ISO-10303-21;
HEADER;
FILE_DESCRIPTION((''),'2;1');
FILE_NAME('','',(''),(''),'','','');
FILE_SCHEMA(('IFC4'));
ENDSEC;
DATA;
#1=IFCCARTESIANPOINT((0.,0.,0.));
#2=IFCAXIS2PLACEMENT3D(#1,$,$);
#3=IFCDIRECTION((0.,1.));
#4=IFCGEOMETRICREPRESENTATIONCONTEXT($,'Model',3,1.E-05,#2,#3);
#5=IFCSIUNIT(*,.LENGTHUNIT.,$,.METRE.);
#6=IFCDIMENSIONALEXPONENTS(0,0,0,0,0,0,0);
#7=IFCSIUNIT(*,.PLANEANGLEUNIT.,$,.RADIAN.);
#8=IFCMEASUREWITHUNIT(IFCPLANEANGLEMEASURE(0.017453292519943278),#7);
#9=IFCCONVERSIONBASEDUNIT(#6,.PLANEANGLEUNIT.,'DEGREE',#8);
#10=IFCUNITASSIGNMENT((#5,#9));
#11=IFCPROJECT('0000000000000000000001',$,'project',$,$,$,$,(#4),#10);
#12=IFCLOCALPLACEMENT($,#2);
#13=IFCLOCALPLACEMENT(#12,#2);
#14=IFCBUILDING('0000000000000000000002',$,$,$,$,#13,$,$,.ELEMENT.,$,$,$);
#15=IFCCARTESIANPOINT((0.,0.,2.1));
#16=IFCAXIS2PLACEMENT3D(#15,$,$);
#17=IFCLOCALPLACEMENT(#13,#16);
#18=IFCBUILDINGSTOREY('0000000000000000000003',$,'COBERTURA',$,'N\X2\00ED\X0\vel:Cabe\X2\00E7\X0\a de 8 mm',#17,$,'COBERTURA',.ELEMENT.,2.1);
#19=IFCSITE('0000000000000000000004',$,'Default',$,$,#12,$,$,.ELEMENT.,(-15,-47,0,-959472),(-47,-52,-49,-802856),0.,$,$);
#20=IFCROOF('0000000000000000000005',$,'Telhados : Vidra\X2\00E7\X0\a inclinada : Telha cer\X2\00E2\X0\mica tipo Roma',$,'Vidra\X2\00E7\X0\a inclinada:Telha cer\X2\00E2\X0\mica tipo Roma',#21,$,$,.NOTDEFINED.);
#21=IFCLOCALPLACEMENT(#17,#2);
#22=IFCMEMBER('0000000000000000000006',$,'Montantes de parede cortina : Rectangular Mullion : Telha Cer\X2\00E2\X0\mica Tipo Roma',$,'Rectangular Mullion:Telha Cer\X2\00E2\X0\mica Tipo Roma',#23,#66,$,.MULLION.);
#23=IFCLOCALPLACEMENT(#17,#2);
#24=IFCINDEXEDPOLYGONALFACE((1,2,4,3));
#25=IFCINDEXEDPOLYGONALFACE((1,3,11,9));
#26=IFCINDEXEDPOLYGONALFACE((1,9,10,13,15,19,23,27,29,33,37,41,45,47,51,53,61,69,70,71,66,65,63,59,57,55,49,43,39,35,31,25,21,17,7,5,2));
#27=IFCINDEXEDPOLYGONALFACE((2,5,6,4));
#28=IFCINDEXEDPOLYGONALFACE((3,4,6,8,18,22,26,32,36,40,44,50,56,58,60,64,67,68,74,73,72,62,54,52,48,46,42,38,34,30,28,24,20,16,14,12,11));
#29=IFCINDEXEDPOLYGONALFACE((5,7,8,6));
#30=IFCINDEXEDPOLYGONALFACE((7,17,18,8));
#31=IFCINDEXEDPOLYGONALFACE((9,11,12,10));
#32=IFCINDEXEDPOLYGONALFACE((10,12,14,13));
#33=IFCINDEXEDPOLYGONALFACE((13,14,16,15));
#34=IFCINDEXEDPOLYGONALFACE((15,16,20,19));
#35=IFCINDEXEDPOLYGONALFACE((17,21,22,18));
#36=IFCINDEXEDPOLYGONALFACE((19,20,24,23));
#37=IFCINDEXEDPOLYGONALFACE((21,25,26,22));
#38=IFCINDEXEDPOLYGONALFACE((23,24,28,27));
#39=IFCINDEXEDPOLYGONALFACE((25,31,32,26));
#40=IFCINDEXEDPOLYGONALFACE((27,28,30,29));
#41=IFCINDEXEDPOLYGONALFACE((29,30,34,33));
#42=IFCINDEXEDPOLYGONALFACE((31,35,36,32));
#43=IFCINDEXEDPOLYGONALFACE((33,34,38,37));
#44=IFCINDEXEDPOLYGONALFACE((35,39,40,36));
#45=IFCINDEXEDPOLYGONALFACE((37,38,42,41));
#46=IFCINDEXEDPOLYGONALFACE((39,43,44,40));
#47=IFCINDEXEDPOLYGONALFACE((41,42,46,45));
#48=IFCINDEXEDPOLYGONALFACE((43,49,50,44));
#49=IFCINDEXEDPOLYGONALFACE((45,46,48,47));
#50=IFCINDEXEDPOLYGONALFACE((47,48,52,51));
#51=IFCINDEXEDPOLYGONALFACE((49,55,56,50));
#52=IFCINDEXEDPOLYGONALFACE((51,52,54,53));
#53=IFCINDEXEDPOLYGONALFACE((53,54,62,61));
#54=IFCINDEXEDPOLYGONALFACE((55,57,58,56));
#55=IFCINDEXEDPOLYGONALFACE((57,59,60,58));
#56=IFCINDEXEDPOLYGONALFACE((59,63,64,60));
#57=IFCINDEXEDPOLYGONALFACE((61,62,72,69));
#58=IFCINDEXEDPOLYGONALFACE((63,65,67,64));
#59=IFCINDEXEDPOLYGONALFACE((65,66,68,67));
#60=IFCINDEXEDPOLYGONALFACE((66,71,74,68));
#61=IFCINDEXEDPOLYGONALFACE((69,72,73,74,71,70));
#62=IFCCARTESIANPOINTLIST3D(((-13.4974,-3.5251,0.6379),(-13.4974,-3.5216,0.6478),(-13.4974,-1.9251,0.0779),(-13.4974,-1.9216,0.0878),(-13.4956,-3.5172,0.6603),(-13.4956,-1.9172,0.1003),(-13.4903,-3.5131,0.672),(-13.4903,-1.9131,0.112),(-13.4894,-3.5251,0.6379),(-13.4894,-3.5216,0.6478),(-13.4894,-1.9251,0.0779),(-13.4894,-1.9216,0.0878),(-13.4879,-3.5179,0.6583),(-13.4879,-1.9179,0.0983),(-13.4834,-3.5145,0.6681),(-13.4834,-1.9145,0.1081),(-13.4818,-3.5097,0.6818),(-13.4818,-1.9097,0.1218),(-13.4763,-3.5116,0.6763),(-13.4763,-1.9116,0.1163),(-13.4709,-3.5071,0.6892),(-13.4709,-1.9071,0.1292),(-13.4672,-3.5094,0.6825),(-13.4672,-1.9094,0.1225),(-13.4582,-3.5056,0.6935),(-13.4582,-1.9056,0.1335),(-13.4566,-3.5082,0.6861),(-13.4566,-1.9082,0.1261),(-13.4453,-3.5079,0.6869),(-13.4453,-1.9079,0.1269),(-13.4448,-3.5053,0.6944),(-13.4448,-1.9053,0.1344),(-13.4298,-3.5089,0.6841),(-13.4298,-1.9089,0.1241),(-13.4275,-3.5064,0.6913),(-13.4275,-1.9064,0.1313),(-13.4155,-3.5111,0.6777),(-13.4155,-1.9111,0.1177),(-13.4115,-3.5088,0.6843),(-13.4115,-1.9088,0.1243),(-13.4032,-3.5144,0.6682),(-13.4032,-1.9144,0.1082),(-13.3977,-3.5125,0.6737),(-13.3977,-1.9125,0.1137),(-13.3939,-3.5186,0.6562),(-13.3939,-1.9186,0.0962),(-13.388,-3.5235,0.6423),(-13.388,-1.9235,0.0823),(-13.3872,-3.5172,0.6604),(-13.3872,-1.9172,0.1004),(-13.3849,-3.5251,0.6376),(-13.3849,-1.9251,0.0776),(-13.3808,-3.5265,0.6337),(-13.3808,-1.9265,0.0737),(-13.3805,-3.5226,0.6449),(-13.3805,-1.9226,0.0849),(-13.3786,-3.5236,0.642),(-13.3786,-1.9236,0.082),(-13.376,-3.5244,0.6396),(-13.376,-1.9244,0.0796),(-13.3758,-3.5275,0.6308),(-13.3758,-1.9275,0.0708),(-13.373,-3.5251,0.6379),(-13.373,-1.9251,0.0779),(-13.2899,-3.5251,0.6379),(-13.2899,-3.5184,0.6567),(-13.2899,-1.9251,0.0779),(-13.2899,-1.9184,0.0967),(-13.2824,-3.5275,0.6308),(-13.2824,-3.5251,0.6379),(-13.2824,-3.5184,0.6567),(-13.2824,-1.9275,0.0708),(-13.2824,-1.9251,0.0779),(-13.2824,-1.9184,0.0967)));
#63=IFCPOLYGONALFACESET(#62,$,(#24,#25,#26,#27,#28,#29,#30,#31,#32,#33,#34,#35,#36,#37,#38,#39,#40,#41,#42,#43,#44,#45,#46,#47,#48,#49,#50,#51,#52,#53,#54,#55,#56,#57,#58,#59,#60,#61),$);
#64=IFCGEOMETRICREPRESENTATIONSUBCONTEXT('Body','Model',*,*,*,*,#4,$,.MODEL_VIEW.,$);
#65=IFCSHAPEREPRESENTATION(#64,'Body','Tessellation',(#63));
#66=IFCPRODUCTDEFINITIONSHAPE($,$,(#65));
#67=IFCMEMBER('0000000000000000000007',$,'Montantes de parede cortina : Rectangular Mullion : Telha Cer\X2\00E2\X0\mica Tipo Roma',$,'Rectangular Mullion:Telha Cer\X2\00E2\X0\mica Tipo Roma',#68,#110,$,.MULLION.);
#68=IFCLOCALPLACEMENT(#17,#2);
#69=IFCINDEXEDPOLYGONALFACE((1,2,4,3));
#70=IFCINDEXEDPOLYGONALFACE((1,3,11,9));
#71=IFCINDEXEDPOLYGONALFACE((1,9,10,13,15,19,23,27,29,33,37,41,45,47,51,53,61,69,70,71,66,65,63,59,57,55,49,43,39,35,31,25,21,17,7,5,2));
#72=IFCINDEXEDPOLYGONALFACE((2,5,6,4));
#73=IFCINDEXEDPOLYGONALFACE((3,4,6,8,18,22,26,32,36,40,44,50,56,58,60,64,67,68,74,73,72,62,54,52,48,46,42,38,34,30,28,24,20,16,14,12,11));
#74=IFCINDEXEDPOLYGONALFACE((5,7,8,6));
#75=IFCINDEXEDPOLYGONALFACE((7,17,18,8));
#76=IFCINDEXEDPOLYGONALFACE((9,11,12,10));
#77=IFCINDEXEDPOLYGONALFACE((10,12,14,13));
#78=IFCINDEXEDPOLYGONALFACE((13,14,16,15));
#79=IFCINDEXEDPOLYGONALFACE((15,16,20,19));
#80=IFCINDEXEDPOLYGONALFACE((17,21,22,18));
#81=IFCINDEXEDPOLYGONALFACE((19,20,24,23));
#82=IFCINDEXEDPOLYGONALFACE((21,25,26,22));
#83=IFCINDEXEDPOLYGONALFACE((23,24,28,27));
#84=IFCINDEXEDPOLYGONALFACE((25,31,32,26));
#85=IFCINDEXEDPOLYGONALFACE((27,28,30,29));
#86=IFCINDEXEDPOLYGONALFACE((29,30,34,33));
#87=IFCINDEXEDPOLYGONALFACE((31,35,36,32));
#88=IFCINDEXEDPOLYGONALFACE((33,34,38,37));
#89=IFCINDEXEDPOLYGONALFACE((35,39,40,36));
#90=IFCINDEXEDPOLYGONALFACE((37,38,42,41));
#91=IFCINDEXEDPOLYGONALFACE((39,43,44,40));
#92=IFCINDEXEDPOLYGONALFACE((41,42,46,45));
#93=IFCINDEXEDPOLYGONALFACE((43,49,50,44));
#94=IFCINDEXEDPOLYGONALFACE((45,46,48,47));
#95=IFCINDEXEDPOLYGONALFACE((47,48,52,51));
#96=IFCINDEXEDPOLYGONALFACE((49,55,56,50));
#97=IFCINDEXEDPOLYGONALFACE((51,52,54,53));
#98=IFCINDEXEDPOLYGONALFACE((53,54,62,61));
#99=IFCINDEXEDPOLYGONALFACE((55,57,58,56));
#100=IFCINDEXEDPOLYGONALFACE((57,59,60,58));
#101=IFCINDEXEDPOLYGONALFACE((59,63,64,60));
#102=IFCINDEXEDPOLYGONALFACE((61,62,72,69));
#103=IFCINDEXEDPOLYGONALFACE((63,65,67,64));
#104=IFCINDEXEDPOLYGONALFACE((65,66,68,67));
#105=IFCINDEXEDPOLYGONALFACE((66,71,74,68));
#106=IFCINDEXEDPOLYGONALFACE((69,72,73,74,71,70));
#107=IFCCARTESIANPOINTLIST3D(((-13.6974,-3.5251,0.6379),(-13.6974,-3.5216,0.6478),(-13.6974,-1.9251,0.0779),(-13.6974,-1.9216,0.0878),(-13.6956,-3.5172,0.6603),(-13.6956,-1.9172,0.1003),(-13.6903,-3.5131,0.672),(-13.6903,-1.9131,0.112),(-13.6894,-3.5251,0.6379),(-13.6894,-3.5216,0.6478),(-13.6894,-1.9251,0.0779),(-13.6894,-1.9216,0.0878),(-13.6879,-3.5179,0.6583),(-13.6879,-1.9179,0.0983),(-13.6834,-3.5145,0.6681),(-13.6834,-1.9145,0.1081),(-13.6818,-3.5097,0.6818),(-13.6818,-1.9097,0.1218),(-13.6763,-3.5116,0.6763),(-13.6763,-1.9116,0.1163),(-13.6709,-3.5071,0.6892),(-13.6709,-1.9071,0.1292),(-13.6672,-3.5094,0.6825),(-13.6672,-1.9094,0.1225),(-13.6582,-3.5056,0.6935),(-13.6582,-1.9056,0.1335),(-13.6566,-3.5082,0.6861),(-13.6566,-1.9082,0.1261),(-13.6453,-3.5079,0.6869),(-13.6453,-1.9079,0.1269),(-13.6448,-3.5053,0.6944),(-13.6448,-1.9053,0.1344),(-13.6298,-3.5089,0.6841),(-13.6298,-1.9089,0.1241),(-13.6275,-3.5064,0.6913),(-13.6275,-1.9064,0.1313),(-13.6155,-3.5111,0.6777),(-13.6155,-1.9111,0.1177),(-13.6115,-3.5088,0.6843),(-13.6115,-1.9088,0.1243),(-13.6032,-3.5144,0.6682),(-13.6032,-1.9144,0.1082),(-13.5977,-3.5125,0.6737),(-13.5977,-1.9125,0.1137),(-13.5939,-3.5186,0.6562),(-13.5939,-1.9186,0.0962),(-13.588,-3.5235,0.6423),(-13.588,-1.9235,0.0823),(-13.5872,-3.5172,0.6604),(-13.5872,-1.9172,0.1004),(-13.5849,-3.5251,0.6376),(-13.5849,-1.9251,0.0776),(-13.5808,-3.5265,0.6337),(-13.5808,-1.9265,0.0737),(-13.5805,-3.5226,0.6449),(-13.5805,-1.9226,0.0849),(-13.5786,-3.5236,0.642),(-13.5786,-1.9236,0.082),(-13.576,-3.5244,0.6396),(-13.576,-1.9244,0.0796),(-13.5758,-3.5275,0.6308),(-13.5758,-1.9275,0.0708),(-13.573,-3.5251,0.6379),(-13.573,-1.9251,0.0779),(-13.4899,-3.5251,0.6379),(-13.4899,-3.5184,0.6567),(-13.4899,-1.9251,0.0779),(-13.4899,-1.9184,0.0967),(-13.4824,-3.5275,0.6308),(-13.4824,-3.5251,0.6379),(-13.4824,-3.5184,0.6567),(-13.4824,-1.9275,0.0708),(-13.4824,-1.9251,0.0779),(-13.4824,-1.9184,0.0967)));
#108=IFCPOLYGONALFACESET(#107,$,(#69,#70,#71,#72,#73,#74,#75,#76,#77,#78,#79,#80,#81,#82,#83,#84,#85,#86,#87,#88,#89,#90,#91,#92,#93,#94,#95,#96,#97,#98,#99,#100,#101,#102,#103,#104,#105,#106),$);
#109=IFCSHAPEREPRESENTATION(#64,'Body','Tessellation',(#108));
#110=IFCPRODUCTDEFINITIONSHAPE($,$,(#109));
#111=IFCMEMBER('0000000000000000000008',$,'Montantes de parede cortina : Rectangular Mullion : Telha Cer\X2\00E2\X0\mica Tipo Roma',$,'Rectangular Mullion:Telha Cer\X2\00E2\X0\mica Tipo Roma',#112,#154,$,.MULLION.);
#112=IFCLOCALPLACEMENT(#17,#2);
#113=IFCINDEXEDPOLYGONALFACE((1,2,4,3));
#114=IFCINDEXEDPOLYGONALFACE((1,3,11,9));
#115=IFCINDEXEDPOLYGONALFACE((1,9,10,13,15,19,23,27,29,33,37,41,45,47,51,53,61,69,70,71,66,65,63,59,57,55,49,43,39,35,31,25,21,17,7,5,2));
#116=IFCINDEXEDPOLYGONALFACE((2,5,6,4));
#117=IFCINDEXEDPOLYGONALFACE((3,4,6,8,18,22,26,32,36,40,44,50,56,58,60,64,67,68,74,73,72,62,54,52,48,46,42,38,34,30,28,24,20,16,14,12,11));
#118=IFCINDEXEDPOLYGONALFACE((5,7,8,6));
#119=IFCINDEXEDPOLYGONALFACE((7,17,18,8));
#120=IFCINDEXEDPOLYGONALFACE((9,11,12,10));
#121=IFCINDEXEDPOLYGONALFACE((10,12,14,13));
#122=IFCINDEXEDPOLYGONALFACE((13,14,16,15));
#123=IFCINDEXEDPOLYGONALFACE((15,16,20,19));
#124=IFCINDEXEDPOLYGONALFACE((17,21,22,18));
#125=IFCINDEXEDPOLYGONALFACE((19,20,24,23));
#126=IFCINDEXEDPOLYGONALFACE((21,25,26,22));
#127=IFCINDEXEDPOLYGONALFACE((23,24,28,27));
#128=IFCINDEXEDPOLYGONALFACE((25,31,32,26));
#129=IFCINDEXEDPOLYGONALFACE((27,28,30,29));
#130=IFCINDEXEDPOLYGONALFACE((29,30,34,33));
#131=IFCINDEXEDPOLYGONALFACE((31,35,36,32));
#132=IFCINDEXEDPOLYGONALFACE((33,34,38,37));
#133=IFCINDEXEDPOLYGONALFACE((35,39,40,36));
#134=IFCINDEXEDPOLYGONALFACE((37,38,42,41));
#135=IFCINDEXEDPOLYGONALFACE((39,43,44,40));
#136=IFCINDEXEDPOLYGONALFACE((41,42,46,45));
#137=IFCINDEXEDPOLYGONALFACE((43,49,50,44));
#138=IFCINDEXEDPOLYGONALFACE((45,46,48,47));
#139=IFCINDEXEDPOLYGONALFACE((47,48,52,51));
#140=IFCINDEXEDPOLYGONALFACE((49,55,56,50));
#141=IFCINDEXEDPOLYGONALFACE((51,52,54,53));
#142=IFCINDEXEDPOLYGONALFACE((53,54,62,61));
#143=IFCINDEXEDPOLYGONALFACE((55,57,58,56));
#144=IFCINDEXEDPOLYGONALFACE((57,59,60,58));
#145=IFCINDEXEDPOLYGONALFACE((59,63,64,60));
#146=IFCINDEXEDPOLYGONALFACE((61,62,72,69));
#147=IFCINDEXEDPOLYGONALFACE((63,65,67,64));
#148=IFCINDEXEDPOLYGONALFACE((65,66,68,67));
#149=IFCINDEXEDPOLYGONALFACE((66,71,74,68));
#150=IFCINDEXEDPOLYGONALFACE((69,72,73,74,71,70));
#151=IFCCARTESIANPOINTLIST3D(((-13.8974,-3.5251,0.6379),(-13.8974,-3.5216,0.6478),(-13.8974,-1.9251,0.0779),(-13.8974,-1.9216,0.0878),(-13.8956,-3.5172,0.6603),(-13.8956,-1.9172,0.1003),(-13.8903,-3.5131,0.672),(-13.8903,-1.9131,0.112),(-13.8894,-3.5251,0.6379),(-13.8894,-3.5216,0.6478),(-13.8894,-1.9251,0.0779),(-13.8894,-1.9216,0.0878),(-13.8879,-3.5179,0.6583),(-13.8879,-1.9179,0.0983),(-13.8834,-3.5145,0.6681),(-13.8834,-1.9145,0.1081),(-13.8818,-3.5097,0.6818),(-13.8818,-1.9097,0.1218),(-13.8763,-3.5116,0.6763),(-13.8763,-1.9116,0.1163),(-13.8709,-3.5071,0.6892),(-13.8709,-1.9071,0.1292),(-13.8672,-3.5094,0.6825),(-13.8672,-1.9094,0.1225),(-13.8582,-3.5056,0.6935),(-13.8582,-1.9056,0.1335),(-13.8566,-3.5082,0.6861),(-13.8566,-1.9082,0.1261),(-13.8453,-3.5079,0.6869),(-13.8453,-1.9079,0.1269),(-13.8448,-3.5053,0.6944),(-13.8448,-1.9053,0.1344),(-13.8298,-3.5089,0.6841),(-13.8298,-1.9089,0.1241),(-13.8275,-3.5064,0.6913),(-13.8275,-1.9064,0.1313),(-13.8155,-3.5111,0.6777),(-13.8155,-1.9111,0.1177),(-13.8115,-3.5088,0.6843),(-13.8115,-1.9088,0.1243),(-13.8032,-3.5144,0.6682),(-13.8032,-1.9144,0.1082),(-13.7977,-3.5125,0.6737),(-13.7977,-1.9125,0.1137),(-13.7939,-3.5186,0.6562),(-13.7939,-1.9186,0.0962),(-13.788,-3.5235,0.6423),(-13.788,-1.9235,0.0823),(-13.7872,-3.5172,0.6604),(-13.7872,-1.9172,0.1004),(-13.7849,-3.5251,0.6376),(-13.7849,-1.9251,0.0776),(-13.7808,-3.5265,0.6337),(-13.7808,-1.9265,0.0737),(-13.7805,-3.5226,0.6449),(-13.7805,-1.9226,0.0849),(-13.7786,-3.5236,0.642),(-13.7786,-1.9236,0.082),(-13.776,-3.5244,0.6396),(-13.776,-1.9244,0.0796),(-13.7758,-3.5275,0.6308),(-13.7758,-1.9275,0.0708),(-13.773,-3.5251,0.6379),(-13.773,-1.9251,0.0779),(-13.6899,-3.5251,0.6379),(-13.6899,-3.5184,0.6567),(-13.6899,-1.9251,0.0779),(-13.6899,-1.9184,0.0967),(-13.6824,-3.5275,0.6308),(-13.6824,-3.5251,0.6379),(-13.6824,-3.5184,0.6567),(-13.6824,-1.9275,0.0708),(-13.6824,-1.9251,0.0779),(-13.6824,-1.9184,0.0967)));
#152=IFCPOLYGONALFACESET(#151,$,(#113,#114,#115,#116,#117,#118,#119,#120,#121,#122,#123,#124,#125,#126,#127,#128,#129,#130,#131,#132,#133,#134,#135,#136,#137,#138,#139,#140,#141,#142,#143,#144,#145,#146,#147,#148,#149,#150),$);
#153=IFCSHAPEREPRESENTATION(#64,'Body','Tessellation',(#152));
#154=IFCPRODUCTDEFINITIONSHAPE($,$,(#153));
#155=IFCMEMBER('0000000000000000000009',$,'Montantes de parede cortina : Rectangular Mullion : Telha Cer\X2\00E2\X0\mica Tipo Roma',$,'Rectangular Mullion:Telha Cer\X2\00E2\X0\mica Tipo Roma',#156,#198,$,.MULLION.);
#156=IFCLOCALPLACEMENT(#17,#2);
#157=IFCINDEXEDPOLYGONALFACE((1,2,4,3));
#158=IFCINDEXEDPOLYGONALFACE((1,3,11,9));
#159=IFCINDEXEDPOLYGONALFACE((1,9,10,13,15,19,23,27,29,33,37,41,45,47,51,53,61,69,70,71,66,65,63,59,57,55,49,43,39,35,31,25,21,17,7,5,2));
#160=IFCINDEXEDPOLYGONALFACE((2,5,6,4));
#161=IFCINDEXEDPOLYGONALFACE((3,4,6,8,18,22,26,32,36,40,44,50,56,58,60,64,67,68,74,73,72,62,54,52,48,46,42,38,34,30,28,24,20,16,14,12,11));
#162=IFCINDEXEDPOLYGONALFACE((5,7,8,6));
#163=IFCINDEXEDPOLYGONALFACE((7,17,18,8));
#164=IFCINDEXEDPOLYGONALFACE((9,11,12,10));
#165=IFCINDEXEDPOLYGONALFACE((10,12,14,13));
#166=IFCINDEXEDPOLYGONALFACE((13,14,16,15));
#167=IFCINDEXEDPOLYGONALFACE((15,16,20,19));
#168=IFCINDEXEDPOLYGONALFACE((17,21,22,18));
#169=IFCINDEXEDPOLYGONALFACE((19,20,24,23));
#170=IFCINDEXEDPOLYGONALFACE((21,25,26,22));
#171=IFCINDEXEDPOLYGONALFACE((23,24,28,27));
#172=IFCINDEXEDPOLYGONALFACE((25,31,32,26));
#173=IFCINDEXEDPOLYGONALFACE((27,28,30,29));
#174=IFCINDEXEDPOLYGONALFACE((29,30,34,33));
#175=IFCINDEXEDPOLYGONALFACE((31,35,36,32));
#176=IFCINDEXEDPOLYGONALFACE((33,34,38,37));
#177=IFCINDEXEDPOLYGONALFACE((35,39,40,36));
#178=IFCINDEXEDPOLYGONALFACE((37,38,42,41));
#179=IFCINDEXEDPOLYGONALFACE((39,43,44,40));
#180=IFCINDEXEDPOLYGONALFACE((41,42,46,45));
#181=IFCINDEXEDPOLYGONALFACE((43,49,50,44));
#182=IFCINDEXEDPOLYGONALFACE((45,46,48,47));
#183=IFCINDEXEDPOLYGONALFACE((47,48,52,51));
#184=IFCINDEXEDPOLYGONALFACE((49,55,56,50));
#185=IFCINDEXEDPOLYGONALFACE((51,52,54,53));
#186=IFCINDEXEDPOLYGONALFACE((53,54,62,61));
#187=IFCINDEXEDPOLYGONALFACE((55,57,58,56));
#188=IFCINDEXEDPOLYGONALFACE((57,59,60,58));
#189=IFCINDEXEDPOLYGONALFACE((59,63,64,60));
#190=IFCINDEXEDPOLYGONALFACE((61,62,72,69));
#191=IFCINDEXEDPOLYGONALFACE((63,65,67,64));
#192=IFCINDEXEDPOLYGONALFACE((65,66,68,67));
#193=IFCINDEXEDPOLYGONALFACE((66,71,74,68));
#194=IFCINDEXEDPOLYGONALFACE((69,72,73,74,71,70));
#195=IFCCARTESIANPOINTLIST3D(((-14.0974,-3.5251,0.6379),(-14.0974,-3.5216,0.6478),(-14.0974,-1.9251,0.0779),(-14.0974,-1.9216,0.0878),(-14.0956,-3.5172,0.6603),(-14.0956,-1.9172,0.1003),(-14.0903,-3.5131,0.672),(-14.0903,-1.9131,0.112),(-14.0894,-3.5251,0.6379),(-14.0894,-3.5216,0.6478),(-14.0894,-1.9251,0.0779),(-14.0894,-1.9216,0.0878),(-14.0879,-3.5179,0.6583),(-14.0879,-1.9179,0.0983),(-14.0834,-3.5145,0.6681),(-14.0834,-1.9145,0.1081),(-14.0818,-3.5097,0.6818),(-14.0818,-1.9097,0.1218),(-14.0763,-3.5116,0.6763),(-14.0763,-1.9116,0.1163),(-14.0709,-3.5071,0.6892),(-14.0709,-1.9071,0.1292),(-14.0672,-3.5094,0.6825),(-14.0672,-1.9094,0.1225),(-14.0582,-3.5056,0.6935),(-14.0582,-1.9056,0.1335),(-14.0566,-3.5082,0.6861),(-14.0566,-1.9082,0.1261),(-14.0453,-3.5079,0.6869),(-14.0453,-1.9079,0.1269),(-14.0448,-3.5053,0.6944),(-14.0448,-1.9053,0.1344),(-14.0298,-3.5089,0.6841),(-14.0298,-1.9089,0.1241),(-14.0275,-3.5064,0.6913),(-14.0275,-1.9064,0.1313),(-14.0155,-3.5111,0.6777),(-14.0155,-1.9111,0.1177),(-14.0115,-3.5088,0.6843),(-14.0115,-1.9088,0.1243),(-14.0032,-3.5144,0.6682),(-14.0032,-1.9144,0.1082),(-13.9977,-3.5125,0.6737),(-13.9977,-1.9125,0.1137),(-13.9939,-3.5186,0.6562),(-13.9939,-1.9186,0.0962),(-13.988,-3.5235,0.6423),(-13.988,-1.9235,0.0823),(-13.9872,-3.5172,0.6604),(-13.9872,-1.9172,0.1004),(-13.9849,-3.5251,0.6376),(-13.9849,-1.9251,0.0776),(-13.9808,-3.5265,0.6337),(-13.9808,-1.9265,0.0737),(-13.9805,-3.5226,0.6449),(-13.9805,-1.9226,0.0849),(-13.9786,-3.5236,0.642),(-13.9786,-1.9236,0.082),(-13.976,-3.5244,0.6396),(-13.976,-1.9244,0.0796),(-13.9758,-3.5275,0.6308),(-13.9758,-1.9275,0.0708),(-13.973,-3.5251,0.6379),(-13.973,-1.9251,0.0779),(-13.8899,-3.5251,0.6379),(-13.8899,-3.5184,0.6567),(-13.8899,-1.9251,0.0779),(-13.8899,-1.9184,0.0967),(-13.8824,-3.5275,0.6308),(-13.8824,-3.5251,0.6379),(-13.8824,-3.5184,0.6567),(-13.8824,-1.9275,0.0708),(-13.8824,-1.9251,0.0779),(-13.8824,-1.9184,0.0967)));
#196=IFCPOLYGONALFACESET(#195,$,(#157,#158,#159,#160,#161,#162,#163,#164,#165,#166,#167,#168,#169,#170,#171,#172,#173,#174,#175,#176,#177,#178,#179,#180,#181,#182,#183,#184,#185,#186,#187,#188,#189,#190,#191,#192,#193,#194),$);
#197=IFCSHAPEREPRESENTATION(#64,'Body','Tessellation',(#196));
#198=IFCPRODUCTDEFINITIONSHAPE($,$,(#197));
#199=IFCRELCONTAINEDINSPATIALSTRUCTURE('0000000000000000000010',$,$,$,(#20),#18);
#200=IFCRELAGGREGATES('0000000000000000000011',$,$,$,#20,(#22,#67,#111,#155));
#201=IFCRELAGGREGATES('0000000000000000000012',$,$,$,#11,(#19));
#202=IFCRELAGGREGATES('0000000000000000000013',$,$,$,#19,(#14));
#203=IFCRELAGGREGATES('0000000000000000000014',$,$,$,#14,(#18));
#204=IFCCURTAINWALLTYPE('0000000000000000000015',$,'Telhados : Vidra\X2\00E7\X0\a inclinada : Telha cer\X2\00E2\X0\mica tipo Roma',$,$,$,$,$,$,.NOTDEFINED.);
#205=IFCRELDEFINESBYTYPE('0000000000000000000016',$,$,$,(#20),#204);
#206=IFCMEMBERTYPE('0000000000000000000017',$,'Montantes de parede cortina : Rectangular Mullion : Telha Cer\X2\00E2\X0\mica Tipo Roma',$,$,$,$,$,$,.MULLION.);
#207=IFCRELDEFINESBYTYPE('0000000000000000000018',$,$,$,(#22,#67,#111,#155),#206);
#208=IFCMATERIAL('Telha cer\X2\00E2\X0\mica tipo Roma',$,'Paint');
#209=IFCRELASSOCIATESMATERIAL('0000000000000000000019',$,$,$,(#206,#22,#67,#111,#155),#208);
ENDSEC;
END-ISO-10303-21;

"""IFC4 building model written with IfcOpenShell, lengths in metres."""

from ifc_helpers import new_model, entity, si_unit, converted_unit, direction, frame, origin, place, context, subcontext, project, spatial, line, arc, indexed_curve, outline, extrude, source, transform, mapped, material, type_object, type_shapes, element, aggregate, save


model = new_model("IFC4")

# Units and contexts
model_context = context("Model", 3, precision=1e-05, world=origin(), true_north=direction((0.0, 1.0)))
body_context = subcontext(model_context, "Body", "Model", "MODEL_VIEW")
ifc_project = project(units=[si_unit("LENGTHUNIT", "METRE"), converted_unit("PLANEANGLEUNIT", "DEGREE", entity("IfcPlaneAngleMeasure", 0.017453292519943278), si_unit("PLANEANGLEUNIT", "RADIAN"), dimensions=[0, 0, 0, 0, 0, 0, 0])], contexts=[model_context])

# Site, building, storey
site_placement = place(None, origin())
site = spatial("IfcSite", under=ifc_project, at=site_placement, Name="Default", CompositionType="ELEMENT", RefLatitude=(-15, -47, 0, -959472), RefLongitude=(-47, -52, -49, -802856), RefElevation=0.0)
building_placement = place(site_placement, origin())
building = spatial("IfcBuilding", under=site, at=building_placement, CompositionType="ELEMENT")
storey_placement = place(building_placement, frame((0.0, 0.0, 2.1)))
storey = spatial("IfcBuildingStorey", under=building, at=storey_placement, Name="COBERTURA", ObjectType="Nível:Cabeça de 8 mm", LongName="COBERTURA", CompositionType="ELEMENT", Elevation=2.1)

# Roof, members
curtain_wall_type_1 = type_object("IfcCurtainWallType", Name="Telhados : Vidraça inclinada : Telha cerâmica tipo Roma", PredefinedType="NOTDEFINED")
roof_1_placement = place(storey_placement, frame((0.0, 0.0, -2.1)))
roof_1 = element("IfcRoof", 1, at=roof_1_placement, inside=storey, type_object=curtain_wall_type_1, Name="Telhados : Vidraça inclinada : Telha cerâmica tipo Roma", ObjectType="Vidraça inclinada:Telha cerâmica tipo Roma", PredefinedType="NOTDEFINED")
ifc_material_1 = material(Name="Telha cerâmica tipo Roma", Category="Paint")
member_type_1 = type_object("IfcMemberType", Name="Montantes de parede cortina : Rectangular Mullion : Telha Cerâmica Tipo Roma", PredefinedType="MULLION", material=ifc_material_1)
shared_shape_1 = source(origin(), body_context, "Body", "SweptSolid", [
    extrude(outline(indexed_curve([(0.0114, -0.0188), (0.1048, -0.0188), (0.1048, -0.0113), (0.1048, 0.0087), (0.0973, 0.0087), (0.0973, -0.0113), (0.0142, -0.0113), (0.0098, -0.0083), (0.0067, -0.0038), (-0.017, 0.0327), (-0.0576, 0.0486), (-0.0946, 0.0352), (-0.1102, -0.0008), (-0.1102, -0.0113), (-0.1022, -0.0113), (-0.1022, -0.0008), (-0.0891, 0.0294), (-0.0581, 0.0406), (-0.0218, 0.0263), (-0.0008, -0.0066), (0.0042, -0.0138)], segments=[line(1, 2, 3, 4, 5, 6, 7), arc(7, 8, 9), arc(9, 10, 11), arc(11, 12, 13), line(13, 14, 15, 16), arc(16, 17, 18), arc(18, 19, 20), arc(20, 21, 1)], self_intersect=False)), frame((-0.0027, -0.0938, -4.3552), z_axis=(0.0, 0.0, 1.0), x_axis=(-1.0, 0.0, 0.0)), (0.0, 0.0, 1.0), 1.6952),
])
type_shapes(member_type_1, [shared_shape_1])
member_1_placement = place(roof_1_placement, frame((-13.3899, -6.063, 3.5387), z_axis=(0.0, -0.943858, 0.33035), x_axis=(-1.0, 0.0, 0.0)))
member_1 = element("IfcMember", 2, at=member_1_placement, type_object=member_type_1, material=ifc_material_1, Name="Montantes de parede cortina : Rectangular Mullion : Telha Cerâmica Tipo Roma", ObjectType="Rectangular Mullion:Telha Cerâmica Tipo Roma", PredefinedType="MULLION", context=body_context, shape_type="MappedRepresentation", body=[
    mapped(shared_shape_1, transform((0.0, 0.0, 0.0), scale=1.0)),
])
member_2_placement = place(roof_1_placement, frame((-13.5899, -6.063, 3.5387), z_axis=(0.0, -0.943858, 0.33035), x_axis=(-1.0, 0.0, 0.0)))
member_2 = element("IfcMember", 3, at=member_2_placement, type_object=member_type_1, material=ifc_material_1, Name="Montantes de parede cortina : Rectangular Mullion : Telha Cerâmica Tipo Roma", ObjectType="Rectangular Mullion:Telha Cerâmica Tipo Roma", PredefinedType="MULLION", context=body_context, shape_type="MappedRepresentation", body=[
    mapped(shared_shape_1, transform((0.0, 0.0, 0.0), scale=1.0)),
])
member_3_placement = place(roof_1_placement, frame((-13.7899, -6.063, 3.5387), z_axis=(0.0, -0.943858, 0.33035), x_axis=(-1.0, 0.0, 0.0)))
member_3 = element("IfcMember", 4, at=member_3_placement, type_object=member_type_1, material=ifc_material_1, Name="Montantes de parede cortina : Rectangular Mullion : Telha Cerâmica Tipo Roma", ObjectType="Rectangular Mullion:Telha Cerâmica Tipo Roma", PredefinedType="MULLION", context=body_context, shape_type="MappedRepresentation", body=[
    mapped(shared_shape_1, transform((0.0, 0.0, 0.0), scale=1.0)),
])
member_4_placement = place(roof_1_placement, frame((-13.9899, -6.063, 3.5387), z_axis=(0.0, -0.943858, 0.33035), x_axis=(-1.0, 0.0, 0.0)))
member_4 = element("IfcMember", 5, at=member_4_placement, type_object=member_type_1, material=ifc_material_1, Name="Montantes de parede cortina : Rectangular Mullion : Telha Cerâmica Tipo Roma", ObjectType="Rectangular Mullion:Telha Cerâmica Tipo Roma", PredefinedType="MULLION", context=body_context, shape_type="MappedRepresentation", body=[
    mapped(shared_shape_1, transform((0.0, 0.0, 0.0), scale=1.0)),
])
aggregate(roof_1, [member_1, member_2, member_3, member_4])

save(model, "model.ifc")
